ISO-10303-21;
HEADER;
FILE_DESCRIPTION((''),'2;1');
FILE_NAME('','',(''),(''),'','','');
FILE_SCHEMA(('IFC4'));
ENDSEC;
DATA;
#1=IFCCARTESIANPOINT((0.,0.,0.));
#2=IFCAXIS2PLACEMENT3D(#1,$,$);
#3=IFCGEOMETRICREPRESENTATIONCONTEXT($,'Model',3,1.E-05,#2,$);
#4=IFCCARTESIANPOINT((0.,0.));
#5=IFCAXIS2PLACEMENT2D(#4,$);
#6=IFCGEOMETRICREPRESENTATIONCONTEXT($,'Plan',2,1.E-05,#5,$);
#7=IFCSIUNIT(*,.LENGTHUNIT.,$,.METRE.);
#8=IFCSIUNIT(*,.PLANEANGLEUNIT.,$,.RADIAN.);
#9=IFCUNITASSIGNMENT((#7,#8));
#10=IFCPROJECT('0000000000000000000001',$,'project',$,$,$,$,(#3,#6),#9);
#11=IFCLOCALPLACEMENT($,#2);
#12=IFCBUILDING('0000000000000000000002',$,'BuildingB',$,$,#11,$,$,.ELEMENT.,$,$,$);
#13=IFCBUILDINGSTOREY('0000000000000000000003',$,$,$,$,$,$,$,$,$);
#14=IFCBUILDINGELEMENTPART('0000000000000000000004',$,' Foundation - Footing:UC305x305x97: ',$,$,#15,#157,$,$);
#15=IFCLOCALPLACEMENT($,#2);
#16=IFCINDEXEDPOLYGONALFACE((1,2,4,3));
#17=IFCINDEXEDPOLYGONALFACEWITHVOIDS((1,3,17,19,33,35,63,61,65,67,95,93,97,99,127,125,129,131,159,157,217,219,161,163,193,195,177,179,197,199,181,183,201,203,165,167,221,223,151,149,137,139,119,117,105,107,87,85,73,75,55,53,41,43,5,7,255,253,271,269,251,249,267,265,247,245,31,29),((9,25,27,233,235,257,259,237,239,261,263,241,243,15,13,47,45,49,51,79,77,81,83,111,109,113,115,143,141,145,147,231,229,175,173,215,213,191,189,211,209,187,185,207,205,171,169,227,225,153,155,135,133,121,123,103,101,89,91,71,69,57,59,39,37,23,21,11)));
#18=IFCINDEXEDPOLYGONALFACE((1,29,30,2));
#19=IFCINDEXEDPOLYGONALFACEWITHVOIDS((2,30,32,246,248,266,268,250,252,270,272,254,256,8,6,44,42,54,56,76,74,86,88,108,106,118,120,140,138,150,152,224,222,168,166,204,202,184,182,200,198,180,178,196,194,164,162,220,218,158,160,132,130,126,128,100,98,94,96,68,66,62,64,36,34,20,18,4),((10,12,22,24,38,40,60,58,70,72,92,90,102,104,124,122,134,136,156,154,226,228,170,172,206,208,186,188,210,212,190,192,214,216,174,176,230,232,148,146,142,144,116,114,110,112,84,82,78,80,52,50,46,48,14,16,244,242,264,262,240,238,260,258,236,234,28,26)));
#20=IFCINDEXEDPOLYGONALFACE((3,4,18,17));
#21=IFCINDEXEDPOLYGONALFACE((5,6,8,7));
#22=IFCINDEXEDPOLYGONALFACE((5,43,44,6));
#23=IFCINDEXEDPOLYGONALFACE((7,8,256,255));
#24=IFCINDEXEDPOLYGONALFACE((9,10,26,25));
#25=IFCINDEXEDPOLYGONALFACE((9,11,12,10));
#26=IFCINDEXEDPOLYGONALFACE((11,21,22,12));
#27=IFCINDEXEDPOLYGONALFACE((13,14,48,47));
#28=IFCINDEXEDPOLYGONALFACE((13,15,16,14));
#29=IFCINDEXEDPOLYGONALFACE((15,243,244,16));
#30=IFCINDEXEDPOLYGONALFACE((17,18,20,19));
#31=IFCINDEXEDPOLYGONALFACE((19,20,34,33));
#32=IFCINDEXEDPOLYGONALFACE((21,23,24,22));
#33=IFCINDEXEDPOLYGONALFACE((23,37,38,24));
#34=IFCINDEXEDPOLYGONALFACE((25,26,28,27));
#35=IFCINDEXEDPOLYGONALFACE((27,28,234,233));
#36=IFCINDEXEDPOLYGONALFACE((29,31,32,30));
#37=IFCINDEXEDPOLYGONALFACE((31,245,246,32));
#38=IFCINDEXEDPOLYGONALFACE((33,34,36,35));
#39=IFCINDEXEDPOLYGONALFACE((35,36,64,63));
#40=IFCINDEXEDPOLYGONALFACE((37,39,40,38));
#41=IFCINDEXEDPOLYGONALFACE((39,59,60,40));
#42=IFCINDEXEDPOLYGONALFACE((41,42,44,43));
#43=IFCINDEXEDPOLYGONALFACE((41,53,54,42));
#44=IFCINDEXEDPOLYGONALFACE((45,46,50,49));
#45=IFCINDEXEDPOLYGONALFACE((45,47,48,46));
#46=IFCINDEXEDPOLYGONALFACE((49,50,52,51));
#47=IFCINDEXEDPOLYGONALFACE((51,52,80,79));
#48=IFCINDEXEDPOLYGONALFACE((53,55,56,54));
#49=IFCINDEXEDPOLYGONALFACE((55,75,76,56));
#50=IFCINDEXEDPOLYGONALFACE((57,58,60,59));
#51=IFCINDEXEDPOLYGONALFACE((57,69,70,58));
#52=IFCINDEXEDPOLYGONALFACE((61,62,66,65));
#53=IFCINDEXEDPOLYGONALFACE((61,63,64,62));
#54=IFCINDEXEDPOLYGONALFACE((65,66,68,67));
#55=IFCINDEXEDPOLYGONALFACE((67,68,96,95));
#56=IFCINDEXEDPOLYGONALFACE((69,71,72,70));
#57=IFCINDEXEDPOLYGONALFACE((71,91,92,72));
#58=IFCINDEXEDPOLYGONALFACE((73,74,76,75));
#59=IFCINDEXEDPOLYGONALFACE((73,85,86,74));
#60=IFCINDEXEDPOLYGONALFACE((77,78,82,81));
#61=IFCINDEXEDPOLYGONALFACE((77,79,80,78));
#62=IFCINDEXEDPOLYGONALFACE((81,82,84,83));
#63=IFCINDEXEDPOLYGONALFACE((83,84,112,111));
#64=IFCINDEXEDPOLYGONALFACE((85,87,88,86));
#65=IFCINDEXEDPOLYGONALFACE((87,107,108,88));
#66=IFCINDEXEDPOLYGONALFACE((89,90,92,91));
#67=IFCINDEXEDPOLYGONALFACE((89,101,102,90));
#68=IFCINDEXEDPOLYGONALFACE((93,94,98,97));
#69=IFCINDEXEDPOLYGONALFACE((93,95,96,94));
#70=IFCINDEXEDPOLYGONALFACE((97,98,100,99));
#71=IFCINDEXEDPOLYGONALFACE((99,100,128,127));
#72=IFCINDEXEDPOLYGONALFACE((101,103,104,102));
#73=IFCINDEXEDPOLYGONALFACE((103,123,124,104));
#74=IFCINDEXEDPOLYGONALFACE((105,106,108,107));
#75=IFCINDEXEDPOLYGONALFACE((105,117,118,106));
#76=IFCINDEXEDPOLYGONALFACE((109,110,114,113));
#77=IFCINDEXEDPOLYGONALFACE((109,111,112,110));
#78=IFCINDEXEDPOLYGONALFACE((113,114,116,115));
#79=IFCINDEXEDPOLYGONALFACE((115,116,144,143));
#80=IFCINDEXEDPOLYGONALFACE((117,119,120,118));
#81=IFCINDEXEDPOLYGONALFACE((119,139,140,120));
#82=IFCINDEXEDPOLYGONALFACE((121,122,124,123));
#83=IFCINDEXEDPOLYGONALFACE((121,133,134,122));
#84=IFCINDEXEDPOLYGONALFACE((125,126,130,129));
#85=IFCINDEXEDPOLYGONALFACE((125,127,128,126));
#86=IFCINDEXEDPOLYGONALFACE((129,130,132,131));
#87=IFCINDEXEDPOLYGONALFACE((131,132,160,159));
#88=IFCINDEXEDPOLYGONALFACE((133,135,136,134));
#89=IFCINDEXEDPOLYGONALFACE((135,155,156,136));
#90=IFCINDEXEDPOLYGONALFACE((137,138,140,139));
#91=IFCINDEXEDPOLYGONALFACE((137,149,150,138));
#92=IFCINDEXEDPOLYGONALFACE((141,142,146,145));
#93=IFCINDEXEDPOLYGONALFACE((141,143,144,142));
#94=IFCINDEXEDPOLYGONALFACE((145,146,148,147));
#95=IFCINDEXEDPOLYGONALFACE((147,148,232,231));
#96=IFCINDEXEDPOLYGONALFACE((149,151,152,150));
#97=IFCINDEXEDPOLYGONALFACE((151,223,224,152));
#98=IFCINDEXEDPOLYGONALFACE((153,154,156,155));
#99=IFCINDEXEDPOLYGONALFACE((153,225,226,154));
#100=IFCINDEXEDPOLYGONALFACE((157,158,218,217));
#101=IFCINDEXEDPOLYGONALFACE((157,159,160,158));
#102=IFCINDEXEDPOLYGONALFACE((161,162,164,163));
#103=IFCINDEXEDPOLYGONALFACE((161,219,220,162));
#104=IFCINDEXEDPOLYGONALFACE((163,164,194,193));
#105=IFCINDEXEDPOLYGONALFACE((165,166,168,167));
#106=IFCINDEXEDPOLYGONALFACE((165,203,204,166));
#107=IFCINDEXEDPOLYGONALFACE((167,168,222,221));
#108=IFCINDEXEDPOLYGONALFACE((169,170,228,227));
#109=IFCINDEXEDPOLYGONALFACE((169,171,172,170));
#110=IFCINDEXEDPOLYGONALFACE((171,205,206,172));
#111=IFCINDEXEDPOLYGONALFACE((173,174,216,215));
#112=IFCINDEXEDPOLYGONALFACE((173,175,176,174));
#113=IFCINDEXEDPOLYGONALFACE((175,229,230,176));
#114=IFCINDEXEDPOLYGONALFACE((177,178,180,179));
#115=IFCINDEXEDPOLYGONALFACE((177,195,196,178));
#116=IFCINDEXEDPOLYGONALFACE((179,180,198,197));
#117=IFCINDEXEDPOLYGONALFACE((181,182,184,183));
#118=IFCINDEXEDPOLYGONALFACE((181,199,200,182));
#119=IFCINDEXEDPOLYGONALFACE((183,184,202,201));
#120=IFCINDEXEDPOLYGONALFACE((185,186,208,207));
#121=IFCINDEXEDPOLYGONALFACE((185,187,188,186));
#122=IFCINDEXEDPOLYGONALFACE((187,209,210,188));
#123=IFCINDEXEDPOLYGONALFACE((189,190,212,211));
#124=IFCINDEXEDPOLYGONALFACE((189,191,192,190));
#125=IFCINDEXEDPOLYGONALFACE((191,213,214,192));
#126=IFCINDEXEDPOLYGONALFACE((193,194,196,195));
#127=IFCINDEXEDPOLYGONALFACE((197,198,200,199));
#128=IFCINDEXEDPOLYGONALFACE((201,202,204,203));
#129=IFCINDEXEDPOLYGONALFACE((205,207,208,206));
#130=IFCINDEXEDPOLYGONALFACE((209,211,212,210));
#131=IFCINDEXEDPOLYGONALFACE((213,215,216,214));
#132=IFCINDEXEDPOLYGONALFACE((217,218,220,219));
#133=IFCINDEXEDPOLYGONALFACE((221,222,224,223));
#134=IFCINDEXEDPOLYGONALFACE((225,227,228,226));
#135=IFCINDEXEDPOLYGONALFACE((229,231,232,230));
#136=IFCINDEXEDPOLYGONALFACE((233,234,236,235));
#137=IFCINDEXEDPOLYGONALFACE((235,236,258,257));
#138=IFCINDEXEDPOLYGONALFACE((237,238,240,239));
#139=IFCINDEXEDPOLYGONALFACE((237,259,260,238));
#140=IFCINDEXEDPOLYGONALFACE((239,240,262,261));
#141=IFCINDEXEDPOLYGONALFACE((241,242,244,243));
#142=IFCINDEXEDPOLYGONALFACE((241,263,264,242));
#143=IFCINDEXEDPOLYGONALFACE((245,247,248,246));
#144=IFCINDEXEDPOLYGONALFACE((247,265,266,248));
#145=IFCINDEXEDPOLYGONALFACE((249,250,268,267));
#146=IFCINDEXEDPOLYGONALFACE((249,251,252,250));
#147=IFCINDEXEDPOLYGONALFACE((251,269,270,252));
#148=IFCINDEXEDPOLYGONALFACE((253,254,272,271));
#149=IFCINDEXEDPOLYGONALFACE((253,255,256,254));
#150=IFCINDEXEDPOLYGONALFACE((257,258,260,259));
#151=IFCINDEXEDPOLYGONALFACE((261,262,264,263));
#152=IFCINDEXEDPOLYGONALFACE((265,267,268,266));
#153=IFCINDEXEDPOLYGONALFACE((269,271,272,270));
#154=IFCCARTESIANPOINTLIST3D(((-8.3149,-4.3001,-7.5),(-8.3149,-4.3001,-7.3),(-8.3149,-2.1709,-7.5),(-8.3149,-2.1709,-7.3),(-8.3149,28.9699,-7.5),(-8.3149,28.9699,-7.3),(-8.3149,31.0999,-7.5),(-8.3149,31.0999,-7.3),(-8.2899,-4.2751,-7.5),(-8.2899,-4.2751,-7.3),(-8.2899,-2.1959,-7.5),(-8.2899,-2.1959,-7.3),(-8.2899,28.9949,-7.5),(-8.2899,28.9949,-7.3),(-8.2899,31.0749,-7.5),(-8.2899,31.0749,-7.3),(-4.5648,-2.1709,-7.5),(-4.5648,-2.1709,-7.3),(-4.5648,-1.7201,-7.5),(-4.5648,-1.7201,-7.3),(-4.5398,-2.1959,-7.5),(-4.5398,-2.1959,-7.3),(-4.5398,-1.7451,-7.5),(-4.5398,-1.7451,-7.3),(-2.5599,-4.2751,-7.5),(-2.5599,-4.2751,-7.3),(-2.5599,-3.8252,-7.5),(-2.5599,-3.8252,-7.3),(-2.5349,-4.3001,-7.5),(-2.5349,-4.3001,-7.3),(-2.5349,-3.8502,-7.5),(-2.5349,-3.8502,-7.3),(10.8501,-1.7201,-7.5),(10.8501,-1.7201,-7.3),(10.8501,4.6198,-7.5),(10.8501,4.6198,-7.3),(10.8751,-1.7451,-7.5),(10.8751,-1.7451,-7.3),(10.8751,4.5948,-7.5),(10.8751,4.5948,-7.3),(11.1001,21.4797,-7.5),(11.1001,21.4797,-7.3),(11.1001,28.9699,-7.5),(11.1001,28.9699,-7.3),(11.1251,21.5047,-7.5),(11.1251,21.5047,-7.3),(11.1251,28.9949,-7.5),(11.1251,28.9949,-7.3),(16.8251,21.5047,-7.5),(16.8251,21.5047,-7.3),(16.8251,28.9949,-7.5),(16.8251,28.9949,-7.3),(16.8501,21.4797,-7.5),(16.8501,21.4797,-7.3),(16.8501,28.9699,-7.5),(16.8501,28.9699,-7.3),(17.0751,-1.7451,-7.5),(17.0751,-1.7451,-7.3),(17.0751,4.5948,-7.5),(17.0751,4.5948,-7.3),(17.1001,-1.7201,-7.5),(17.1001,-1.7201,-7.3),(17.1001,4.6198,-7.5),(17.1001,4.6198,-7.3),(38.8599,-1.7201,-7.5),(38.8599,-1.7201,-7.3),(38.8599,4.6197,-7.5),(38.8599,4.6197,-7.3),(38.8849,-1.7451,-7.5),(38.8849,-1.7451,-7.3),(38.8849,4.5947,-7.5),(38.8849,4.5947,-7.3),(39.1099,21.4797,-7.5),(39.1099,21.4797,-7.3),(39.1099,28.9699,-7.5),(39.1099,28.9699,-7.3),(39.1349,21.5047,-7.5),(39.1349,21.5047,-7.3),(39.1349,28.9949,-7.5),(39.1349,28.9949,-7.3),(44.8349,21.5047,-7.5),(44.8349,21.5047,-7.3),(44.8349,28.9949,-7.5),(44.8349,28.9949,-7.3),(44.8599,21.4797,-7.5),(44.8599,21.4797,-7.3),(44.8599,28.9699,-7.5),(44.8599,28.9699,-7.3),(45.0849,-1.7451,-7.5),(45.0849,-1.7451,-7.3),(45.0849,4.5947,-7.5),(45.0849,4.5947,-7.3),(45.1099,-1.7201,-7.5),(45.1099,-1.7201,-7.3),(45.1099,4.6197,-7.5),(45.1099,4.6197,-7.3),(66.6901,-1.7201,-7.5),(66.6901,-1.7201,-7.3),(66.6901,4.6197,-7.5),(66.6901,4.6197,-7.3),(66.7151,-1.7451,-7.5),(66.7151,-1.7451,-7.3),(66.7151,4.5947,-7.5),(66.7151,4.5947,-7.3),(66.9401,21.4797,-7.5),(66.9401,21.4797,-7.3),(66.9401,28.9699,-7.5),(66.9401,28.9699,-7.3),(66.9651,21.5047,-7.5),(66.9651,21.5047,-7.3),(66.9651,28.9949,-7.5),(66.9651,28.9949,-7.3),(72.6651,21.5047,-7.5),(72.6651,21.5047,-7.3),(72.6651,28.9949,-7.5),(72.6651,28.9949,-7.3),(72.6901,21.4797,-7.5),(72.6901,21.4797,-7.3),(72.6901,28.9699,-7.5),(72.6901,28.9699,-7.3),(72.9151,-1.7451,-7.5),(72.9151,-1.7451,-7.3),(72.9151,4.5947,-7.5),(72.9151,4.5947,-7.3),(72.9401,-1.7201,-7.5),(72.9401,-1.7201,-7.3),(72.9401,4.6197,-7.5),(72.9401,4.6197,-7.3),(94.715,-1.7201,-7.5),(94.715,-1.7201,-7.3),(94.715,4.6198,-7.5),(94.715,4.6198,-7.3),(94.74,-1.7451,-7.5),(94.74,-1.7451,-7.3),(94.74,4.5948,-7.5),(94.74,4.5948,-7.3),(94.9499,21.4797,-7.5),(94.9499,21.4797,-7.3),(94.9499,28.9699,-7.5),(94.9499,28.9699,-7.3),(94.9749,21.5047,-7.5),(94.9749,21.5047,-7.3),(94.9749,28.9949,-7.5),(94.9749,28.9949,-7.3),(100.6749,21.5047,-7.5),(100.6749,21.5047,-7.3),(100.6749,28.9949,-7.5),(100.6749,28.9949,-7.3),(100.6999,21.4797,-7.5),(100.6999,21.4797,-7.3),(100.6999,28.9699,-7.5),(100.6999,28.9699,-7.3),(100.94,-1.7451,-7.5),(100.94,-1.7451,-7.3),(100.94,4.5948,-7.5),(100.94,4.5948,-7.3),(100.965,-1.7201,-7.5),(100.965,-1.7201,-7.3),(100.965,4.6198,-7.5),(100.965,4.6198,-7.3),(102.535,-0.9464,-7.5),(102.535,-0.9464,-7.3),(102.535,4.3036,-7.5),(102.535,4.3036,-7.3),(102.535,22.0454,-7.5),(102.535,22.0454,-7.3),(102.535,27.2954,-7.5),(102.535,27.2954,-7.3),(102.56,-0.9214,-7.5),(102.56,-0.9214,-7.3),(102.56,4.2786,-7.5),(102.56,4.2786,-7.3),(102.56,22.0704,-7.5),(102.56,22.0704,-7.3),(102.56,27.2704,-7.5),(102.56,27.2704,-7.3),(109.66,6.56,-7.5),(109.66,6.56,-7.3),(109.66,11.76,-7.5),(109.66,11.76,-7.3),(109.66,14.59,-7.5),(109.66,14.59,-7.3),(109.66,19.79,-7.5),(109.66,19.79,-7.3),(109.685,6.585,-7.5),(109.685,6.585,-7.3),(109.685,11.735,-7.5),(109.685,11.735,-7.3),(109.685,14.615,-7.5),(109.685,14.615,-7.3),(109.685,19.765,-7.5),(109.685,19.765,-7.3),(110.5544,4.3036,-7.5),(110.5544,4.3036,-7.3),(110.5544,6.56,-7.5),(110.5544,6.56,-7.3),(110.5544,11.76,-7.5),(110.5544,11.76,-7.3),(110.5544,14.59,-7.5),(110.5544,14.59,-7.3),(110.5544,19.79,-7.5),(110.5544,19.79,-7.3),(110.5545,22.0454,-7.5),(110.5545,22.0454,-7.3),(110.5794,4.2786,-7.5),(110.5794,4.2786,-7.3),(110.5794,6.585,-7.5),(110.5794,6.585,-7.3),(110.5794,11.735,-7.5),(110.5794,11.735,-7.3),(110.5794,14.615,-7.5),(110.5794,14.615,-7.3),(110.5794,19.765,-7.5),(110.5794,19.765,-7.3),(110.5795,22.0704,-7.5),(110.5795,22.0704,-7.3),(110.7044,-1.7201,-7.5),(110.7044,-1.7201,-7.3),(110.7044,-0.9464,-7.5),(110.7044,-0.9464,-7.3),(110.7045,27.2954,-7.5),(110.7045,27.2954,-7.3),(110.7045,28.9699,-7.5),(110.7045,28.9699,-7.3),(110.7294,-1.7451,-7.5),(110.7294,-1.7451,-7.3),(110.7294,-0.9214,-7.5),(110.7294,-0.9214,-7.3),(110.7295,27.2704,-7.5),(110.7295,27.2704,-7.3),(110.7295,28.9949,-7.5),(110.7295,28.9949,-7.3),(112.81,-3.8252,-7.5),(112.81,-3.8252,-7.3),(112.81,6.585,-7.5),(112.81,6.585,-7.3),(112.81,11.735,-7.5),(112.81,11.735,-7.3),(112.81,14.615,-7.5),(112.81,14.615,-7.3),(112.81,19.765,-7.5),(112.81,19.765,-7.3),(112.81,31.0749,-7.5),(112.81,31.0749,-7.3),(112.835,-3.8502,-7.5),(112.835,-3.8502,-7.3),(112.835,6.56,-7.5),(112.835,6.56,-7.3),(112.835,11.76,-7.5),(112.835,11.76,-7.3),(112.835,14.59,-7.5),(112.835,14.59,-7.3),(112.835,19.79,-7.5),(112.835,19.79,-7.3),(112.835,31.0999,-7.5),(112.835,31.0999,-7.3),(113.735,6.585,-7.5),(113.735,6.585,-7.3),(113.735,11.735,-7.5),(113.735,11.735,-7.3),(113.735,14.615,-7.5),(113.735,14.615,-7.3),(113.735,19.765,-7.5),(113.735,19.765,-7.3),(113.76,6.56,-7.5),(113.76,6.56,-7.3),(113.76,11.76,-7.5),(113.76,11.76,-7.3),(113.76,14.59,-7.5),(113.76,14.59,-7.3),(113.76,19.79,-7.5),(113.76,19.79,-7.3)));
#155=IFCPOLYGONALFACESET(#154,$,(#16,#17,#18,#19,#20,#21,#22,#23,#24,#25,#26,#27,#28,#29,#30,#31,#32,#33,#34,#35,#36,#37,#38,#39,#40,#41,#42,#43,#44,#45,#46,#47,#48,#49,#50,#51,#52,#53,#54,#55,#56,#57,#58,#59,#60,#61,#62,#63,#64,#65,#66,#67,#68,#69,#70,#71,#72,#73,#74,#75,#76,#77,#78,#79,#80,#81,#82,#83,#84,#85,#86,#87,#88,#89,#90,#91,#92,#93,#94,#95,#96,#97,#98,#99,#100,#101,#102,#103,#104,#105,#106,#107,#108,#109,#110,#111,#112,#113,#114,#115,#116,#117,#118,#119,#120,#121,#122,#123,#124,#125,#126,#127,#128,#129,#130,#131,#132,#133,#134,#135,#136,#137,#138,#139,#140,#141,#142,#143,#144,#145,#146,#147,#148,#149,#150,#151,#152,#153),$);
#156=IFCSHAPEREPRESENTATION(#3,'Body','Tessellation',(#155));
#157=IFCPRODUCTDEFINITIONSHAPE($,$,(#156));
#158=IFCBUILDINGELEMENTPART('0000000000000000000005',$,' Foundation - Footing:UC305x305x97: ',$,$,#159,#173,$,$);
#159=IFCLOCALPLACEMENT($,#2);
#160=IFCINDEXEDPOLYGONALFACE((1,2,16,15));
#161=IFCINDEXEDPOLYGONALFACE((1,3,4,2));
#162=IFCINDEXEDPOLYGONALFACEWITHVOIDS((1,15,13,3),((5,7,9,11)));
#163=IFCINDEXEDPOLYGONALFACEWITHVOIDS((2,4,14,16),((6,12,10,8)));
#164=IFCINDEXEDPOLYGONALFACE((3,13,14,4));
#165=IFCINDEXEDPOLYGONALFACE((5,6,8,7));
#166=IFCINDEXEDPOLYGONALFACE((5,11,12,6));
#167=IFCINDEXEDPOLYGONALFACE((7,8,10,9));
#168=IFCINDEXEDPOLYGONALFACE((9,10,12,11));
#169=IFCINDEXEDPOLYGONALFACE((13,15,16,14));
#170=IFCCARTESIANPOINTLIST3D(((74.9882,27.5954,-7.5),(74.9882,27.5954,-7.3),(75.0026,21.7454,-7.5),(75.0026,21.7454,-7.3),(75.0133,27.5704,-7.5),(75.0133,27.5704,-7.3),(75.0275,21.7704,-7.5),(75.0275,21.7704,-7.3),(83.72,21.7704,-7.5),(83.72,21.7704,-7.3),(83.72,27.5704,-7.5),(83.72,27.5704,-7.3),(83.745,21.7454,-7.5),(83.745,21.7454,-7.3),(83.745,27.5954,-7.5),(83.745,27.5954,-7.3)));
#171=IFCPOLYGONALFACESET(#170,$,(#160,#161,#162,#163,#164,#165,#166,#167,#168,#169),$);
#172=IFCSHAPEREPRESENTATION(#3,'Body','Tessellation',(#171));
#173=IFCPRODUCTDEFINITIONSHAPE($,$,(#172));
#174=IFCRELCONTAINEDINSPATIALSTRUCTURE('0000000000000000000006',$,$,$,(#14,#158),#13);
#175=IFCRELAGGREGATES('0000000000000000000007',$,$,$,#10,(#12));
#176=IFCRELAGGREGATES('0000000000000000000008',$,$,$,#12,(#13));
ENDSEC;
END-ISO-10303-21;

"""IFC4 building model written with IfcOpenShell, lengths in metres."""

from ifc_helpers import new_model, si_unit, origin, origin_2d, place, context, project, spatial, polyline, outline, extrude, element, save


model = new_model("IFC4")

# Units and contexts
model_context = context("Model", 3, precision=1e-05, world=origin())
plan_context = context("Plan", 2, precision=1e-05, world=origin_2d())
ifc_project = project(units=[si_unit("LENGTHUNIT", "METRE"), si_unit("PLANEANGLEUNIT", "RADIAN")], contexts=[model_context, plan_context])

# Building, storey
building_placement = place(None, origin())
building = spatial("IfcBuilding", under=ifc_project, at=building_placement, Name="BuildingB", CompositionType="ELEMENT")
storey = spatial("IfcBuildingStorey", under=building)

# Building element parts, openings
building_element_part_1 = element("IfcBuildingElementPart", 1, inside=storey, Name=" Foundation - Footing:UC305x305x97: ", context=model_context, shape_type="SweptSolid", body=[
    extrude(outline(polyline([(-8.3149, 31.0999, -7.5), (-8.3149, 28.9699, -7.5), (11.1001, 28.9699, -7.5), (11.1001, 21.4797, -7.5), (16.8501, 21.4797, -7.5), (16.8501, 28.9699, -7.5), (39.1099, 28.9699, -7.5), (39.1099, 21.4797, -7.5), (44.8599, 21.4797, -7.5), (44.8599, 28.9699, -7.5), (66.9401, 28.9699, -7.5), (66.9401, 21.4797, -7.5), (72.6901, 21.4797, -7.5), (72.6901, 28.9699, -7.5), (94.9499, 28.9699, -7.5), (94.9499, 21.4797, -7.5), (100.6999, 21.4797, -7.5), (100.6999, 28.9699, -7.5), (110.7045, 28.9699, -7.5), (110.7045, 27.2954, -7.5), (102.535, 27.2954, -7.5), (102.535, 22.0454, -7.5), (110.5545, 22.0454, -7.5), (110.5544, 19.79, -7.5), (109.66, 19.79, -7.5), (109.66, 14.59, -7.5), (110.5544, 14.59, -7.5), (110.5544, 11.76, -7.5), (109.66, 11.76, -7.5), (109.66, 6.56, -7.5), (110.5544, 6.56, -7.5), (110.5544, 4.3036, -7.5), (102.535, 4.3036, -7.5), (102.535, -0.9464, -7.5), (110.7044, -0.9464, -7.5), (110.7044, -1.7201, -7.5), (100.965, -1.7201, -7.5), (100.965, 4.6198, -7.5), (94.715, 4.6198, -7.5), (94.715, -1.7201, -7.5), (72.9401, -1.7201, -7.5), (72.9401, 4.6197, -7.5), (66.6901, 4.6197, -7.5), (66.6901, -1.7201, -7.5), (45.1099, -1.7201, -7.5), (45.1099, 4.6197, -7.5), (38.8599, 4.6197, -7.5), (38.8599, -1.7201, -7.5), (17.1001, -1.7201, -7.5), (17.1001, 4.6198, -7.5), (10.8501, 4.6198, -7.5), (10.8501, -1.7201, -7.5), (-4.5648, -1.7201, -7.5), (-4.5648, -2.1709, -7.5), (-8.3149, -2.1709, -7.5), (-8.3149, -4.3001, -7.5), (-2.5349, -4.3001, -7.5), (-2.5349, -3.8502, -7.5), (112.835, -3.8502, -7.5), (112.835, 6.56, -7.5), (113.76, 6.56, -7.5), (113.76, 11.76, -7.5), (112.835, 11.76, -7.5), (112.835, 14.59, -7.5), (113.76, 14.59, -7.5), (113.76, 19.79, -7.5), (112.835, 19.79, -7.5), (112.835, 31.0999, -7.5), (-8.3149, 31.0999, -7.5)])), None, (0.0, 0.0, 1.0), 0.2),
])
element("IfcOpeningElement", 2, inside=storey, cuts=building_element_part_1, context=model_context, shape_type="SweptSolid", body=[
    extrude(outline(polyline([(-8.2899, 31.0749, -7.5), (-8.2899, 28.9949, -7.5), (11.1251, 28.9949, -7.5), (11.1251, 21.5047, -7.5), (16.8251, 21.5047, -7.5), (16.8251, 28.9949, -7.5), (39.1349, 28.9949, -7.5), (39.1349, 21.5047, -7.5), (44.8349, 21.5047, -7.5), (44.8349, 28.9949, -7.5), (66.9651, 28.9949, -7.5), (66.9651, 21.5047, -7.5), (72.6651, 21.5047, -7.5), (72.6651, 28.9949, -7.5), (94.9749, 28.9949, -7.5), (94.9749, 21.5047, -7.5), (100.6749, 21.5047, -7.5), (100.6749, 28.9949, -7.5), (110.7295, 28.9949, -7.5), (110.7295, 27.2704, -7.5), (102.56, 27.2704, -7.5), (102.56, 22.0704, -7.5), (110.5795, 22.0704, -7.5), (110.5794, 19.765, -7.5), (109.685, 19.765, -7.5), (109.685, 14.615, -7.5), (110.5794, 14.615, -7.5), (110.5794, 11.735, -7.5), (109.685, 11.735, -7.5), (109.685, 6.585, -7.5), (110.5794, 6.585, -7.5), (110.5794, 4.2786, -7.5), (102.56, 4.2786, -7.5), (102.56, -0.9214, -7.5), (110.7294, -0.9214, -7.5), (110.7294, -1.7451, -7.5), (100.94, -1.7451, -7.5), (100.94, 4.5948, -7.5), (94.74, 4.5948, -7.5), (94.74, -1.7451, -7.5), (72.9151, -1.7451, -7.5), (72.9151, 4.5947, -7.5), (66.7151, 4.5947, -7.5), (66.7151, -1.7451, -7.5), (45.0849, -1.7451, -7.5), (45.0849, 4.5947, -7.5), (38.8849, 4.5947, -7.5), (38.8849, -1.7451, -7.5), (17.0751, -1.7451, -7.5), (17.0751, 4.5948, -7.5), (10.8751, 4.5948, -7.5), (10.8751, -1.7451, -7.5), (-4.5398, -1.7451, -7.5), (-4.5398, -2.1959, -7.5), (-8.2899, -2.1959, -7.5), (-8.2899, -4.2751, -7.5), (-2.5599, -4.2751, -7.5), (-2.5599, -3.8252, -7.5), (112.81, -3.8252, -7.5), (112.81, 6.585, -7.5), (113.735, 6.585, -7.5), (113.735, 11.735, -7.5), (112.81, 11.735, -7.5), (112.81, 14.615, -7.5), (113.735, 14.615, -7.5), (113.735, 19.765, -7.5), (112.81, 19.765, -7.5), (112.81, 31.0749, -7.5), (-8.2899, 31.0749, -7.5)])), None, (0.0, 0.0, 1.0), 0.2),
])
building_element_part_2 = element("IfcBuildingElementPart", 3, inside=storey, Name=" Foundation - Footing:UC305x305x97: ", context=model_context, shape_type="SweptSolid", body=[
    extrude(outline(polyline([(75.0026, 21.7454, -7.5), (83.745, 21.7454, -7.5), (83.745, 27.5954, -7.5), (74.9882, 27.5954, -7.5), (75.0026, 21.7454, -7.5)])), None, (0.0, 0.0, 1.0), 0.2),
])
element("IfcOpeningElement", 4, inside=storey, cuts=building_element_part_2, context=model_context, shape_type="SweptSolid", body=[
    extrude(outline(polyline([(75.0275, 21.7704, -7.5), (83.72, 21.7704, -7.5), (83.72, 27.5704, -7.5), (75.0133, 27.5704, -7.5), (75.0275, 21.7704, -7.5)])), None, (0.0, 0.0, 1.0), 0.2),
])

save(model, "model.ifc")
